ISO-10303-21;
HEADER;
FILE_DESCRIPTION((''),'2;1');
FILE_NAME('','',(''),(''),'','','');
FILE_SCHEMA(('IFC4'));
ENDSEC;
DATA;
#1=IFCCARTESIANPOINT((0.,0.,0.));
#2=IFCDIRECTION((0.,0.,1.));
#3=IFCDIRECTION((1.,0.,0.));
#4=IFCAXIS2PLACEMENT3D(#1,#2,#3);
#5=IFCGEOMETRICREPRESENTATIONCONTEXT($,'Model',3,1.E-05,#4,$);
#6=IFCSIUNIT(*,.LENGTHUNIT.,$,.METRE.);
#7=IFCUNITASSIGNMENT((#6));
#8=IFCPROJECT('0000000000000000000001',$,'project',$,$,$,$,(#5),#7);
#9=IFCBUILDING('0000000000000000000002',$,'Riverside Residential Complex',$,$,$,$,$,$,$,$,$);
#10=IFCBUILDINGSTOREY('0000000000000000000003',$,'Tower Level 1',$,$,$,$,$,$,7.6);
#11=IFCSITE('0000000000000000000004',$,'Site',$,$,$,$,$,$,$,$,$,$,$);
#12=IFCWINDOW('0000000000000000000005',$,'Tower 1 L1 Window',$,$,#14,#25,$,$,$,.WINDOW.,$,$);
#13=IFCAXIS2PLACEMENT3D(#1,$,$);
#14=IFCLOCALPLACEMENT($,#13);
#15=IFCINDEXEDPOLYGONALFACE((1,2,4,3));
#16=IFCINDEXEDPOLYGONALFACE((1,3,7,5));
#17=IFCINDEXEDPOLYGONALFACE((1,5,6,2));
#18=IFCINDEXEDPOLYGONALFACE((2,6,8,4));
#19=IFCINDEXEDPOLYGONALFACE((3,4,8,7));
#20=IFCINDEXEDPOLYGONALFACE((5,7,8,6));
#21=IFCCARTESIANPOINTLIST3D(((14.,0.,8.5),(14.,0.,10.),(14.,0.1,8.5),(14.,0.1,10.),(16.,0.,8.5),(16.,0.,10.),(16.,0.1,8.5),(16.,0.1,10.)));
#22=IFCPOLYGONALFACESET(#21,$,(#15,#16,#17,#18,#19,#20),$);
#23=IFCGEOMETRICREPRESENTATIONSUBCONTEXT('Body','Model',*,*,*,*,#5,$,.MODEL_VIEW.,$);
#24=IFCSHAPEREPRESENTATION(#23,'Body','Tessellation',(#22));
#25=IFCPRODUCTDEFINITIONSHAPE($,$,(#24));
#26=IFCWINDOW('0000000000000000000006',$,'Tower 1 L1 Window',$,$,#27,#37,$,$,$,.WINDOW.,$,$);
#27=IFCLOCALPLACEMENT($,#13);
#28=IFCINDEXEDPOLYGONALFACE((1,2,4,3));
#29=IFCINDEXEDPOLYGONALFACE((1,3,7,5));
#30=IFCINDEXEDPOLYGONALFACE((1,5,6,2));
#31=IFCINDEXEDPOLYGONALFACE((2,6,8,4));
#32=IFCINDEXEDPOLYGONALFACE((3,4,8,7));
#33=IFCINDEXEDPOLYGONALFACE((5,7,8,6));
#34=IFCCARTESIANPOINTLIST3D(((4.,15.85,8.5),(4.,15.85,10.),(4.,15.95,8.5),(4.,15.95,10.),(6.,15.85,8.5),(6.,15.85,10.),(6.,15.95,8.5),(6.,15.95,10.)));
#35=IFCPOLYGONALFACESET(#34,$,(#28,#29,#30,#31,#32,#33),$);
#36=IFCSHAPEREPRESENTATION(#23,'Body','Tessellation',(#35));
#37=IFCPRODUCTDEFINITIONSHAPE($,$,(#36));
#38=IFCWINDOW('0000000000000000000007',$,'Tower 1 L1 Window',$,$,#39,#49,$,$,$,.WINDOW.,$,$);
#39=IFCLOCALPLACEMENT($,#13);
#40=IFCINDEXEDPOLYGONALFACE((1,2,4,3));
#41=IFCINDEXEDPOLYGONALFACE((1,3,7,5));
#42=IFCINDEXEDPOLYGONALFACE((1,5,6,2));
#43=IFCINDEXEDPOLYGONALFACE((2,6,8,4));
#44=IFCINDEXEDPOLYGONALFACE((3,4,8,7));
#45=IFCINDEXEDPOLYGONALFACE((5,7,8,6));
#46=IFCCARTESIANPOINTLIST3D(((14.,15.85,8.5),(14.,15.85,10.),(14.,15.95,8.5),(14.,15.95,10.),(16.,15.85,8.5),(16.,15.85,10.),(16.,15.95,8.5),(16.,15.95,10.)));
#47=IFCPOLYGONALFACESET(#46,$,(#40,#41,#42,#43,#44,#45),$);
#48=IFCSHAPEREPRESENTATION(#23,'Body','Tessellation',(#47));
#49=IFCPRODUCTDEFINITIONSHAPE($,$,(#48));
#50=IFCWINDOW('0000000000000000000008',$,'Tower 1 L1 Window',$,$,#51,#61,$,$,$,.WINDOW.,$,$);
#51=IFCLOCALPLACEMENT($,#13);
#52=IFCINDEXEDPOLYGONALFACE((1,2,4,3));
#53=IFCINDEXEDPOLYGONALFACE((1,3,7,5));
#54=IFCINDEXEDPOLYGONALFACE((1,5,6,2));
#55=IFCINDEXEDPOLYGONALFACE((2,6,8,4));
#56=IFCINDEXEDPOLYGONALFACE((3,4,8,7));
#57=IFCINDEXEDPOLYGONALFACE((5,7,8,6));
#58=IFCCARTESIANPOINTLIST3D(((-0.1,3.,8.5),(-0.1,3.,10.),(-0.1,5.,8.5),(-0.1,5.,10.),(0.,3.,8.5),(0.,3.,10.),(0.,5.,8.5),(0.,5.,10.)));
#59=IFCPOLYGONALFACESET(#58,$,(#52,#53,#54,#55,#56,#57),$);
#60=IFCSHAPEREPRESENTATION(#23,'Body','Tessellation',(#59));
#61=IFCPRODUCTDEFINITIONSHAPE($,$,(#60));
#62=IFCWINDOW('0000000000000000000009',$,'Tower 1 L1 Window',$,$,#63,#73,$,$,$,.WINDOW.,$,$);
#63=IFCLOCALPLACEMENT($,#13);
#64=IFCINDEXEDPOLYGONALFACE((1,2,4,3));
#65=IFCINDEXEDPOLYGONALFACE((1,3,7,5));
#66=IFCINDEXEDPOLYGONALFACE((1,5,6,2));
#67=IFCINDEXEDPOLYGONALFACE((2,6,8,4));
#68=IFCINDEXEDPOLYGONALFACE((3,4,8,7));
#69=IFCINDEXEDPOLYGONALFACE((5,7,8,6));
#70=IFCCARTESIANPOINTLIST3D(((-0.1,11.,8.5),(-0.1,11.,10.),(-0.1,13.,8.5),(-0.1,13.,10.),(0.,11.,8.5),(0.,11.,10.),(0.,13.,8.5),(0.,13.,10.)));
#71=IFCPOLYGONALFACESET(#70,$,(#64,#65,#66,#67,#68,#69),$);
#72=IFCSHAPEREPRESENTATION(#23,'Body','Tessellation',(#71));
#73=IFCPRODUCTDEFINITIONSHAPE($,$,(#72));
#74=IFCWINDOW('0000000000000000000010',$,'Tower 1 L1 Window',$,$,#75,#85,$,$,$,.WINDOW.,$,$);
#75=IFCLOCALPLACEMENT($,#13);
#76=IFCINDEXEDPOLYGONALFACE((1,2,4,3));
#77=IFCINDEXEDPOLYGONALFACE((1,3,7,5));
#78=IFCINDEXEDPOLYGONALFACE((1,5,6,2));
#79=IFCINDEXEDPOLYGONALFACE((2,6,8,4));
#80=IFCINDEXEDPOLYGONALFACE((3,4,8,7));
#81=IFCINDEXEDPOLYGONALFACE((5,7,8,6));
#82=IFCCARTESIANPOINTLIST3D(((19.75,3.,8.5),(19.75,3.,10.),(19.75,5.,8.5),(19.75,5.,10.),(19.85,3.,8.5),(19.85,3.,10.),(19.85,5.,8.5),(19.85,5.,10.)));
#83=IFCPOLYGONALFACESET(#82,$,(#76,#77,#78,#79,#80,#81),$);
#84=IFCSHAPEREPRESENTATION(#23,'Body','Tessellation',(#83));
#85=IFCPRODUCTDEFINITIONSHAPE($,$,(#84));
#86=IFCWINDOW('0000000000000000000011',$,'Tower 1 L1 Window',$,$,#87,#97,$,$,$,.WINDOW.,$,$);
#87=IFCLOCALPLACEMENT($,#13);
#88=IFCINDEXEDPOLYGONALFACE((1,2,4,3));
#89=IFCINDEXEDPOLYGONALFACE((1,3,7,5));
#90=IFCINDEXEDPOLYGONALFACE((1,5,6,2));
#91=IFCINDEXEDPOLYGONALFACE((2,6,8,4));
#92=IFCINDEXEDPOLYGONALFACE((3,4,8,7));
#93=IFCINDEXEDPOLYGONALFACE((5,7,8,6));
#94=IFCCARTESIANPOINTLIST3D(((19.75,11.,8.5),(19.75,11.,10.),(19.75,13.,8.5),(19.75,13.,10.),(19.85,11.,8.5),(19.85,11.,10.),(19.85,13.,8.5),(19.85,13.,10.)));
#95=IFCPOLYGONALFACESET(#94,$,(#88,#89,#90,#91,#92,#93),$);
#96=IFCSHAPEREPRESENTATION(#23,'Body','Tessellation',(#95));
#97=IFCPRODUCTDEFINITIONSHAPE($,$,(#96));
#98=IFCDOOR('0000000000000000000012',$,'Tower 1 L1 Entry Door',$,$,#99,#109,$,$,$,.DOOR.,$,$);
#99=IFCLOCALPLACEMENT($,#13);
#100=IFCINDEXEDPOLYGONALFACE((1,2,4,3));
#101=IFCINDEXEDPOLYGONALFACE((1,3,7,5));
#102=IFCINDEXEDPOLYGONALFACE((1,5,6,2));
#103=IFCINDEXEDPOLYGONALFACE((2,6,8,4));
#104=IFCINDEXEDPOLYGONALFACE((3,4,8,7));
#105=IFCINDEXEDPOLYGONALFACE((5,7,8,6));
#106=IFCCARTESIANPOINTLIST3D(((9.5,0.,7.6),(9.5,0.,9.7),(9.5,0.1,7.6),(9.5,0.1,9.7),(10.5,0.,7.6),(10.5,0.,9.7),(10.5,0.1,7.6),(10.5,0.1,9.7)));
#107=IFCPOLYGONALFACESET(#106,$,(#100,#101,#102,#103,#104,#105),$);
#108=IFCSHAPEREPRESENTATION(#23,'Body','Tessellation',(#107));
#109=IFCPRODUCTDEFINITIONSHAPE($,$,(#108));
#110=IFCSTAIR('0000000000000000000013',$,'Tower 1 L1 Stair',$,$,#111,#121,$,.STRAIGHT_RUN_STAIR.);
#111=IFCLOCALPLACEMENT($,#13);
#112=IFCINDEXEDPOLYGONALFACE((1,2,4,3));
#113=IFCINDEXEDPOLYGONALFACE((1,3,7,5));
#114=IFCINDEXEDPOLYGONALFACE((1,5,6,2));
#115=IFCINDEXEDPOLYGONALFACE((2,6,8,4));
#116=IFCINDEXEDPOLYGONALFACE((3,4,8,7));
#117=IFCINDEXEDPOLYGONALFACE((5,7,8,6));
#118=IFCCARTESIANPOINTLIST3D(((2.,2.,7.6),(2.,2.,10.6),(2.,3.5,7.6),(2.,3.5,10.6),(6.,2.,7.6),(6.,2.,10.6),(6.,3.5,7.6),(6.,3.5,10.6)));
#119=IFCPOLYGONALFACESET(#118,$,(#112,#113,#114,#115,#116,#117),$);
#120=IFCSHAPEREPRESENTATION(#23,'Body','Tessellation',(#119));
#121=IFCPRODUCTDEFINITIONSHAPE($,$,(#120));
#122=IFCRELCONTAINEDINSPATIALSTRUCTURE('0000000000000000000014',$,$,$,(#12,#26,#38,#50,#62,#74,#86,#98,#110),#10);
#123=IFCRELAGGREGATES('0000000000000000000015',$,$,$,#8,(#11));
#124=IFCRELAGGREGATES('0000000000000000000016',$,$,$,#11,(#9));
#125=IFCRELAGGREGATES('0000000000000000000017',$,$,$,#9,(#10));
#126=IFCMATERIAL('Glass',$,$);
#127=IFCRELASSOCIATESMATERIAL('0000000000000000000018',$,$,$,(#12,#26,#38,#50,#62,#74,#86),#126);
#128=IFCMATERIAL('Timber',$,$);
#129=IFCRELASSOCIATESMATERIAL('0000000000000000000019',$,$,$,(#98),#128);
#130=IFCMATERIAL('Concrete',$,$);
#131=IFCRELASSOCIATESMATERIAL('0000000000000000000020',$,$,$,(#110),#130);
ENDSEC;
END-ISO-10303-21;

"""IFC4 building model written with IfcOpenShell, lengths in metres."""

from ifc_helpers import new_model, si_unit, frame, origin_with_axes, place, context, subcontext, project, spatial, line, indexed_curve, outline, extrude, material, element, save


model = new_model("IFC4")

# Units and contexts
model_context = context("Model", 3, precision=1e-05, world=origin_with_axes())
body_context = subcontext(model_context, "Body", "Model", "MODEL_VIEW")
ifc_project = project(units=[si_unit("LENGTHUNIT", "METRE")], contexts=[model_context])

# Site, building, storey
site = spatial("IfcSite", under=ifc_project, Name="Site")
building = spatial("IfcBuilding", under=site, Name="Riverside Residential Complex")
storey = spatial("IfcBuildingStorey", under=building, Name="Tower Level 1", Elevation=7.6)

# Shared definitions
ifc_material_1 = material(Name="Concrete")

# Windows
ifc_material_2 = material(Name="Glass")
for number, where, z_axis, x_axis, name in (
    (1, (14.0, 0.0, 8.5), (0.0, 0.0, 1.0), (1.0, 0.0, 0.0), "Tower 1 L1 Window"),
    (2, (4.0, 15.85, 8.5), (0.0, 0.0, 1.0), (1.0, 0.0, 0.0), "Tower 1 L1 Window"),
    (3, (14.0, 15.85, 8.5), (0.0, 0.0, 1.0), (1.0, 0.0, 0.0), "Tower 1 L1 Window"),
    (4, (0.0, 3.0, 8.5), (0.0, 0.0, 1.0), (0.0, 1.0, 0.0), "Tower 1 L1 Window"),
    (5, (0.0, 11.0, 8.5), (0.0, 0.0, 1.0), (0.0, 1.0, 0.0), "Tower 1 L1 Window"),
    (6, (19.85, 3.0, 8.5), (0.0, 0.0, 1.0), (0.0, 1.0, 0.0), "Tower 1 L1 Window"),
    (7, (19.85, 11.0, 8.5), (0.0, 0.0, 1.0), (0.0, 1.0, 0.0), "Tower 1 L1 Window"),
):
    element("IfcWindow", number, at=place(None, frame(where, z_axis=z_axis, x_axis=x_axis)), inside=storey, material=ifc_material_2, Name=name, PredefinedType="WINDOW", context=body_context, shape_type="SweptSolid", body=[
        extrude(outline(indexed_curve([(0.0, 0.0), (2.0, 0.0), (2.0, 0.1), (0.0, 0.1)], segments=[line(1, 2, 3, 4, 1)])), origin_with_axes(), (0.0, 0.0, 1.0), 1.5),
    ])

# Door
ifc_material_3 = material(Name="Timber")
door_placement = place(None, frame((9.5, 0.0, 7.6), z_axis=(0.0, 0.0, 1.0), x_axis=(1.0, 0.0, 0.0)))
element("IfcDoor", 8, at=door_placement, inside=storey, material=ifc_material_3, Name="Tower 1 L1 Entry Door", PredefinedType="DOOR", context=body_context, shape_type="SweptSolid", body=[
    extrude(outline(indexed_curve([(0.0, 0.0), (1.0, 0.0), (1.0, 0.1), (0.0, 0.1)], segments=[line(1, 2, 3, 4, 1)])), origin_with_axes(), (0.0, 0.0, 1.0), 2.1),
])

# Stair
stair_placement = place(None, frame((2.0, 2.0, 7.6), z_axis=(0.0, 0.0, 1.0), x_axis=(1.0, 0.0, 0.0)))
element("IfcStair", 9, at=stair_placement, inside=storey, material=ifc_material_1, Name="Tower 1 L1 Stair", PredefinedType="STRAIGHT_RUN_STAIR", context=body_context, shape_type="SweptSolid", body=[
    extrude(outline(indexed_curve([(0.0, 0.0), (4.0, 0.0), (4.0, 1.5), (0.0, 1.5)], segments=[line(1, 2, 3, 4, 1)])), origin_with_axes(), (0.0, 0.0, 1.0), 3.0),
])

save(model, "model.ifc")
